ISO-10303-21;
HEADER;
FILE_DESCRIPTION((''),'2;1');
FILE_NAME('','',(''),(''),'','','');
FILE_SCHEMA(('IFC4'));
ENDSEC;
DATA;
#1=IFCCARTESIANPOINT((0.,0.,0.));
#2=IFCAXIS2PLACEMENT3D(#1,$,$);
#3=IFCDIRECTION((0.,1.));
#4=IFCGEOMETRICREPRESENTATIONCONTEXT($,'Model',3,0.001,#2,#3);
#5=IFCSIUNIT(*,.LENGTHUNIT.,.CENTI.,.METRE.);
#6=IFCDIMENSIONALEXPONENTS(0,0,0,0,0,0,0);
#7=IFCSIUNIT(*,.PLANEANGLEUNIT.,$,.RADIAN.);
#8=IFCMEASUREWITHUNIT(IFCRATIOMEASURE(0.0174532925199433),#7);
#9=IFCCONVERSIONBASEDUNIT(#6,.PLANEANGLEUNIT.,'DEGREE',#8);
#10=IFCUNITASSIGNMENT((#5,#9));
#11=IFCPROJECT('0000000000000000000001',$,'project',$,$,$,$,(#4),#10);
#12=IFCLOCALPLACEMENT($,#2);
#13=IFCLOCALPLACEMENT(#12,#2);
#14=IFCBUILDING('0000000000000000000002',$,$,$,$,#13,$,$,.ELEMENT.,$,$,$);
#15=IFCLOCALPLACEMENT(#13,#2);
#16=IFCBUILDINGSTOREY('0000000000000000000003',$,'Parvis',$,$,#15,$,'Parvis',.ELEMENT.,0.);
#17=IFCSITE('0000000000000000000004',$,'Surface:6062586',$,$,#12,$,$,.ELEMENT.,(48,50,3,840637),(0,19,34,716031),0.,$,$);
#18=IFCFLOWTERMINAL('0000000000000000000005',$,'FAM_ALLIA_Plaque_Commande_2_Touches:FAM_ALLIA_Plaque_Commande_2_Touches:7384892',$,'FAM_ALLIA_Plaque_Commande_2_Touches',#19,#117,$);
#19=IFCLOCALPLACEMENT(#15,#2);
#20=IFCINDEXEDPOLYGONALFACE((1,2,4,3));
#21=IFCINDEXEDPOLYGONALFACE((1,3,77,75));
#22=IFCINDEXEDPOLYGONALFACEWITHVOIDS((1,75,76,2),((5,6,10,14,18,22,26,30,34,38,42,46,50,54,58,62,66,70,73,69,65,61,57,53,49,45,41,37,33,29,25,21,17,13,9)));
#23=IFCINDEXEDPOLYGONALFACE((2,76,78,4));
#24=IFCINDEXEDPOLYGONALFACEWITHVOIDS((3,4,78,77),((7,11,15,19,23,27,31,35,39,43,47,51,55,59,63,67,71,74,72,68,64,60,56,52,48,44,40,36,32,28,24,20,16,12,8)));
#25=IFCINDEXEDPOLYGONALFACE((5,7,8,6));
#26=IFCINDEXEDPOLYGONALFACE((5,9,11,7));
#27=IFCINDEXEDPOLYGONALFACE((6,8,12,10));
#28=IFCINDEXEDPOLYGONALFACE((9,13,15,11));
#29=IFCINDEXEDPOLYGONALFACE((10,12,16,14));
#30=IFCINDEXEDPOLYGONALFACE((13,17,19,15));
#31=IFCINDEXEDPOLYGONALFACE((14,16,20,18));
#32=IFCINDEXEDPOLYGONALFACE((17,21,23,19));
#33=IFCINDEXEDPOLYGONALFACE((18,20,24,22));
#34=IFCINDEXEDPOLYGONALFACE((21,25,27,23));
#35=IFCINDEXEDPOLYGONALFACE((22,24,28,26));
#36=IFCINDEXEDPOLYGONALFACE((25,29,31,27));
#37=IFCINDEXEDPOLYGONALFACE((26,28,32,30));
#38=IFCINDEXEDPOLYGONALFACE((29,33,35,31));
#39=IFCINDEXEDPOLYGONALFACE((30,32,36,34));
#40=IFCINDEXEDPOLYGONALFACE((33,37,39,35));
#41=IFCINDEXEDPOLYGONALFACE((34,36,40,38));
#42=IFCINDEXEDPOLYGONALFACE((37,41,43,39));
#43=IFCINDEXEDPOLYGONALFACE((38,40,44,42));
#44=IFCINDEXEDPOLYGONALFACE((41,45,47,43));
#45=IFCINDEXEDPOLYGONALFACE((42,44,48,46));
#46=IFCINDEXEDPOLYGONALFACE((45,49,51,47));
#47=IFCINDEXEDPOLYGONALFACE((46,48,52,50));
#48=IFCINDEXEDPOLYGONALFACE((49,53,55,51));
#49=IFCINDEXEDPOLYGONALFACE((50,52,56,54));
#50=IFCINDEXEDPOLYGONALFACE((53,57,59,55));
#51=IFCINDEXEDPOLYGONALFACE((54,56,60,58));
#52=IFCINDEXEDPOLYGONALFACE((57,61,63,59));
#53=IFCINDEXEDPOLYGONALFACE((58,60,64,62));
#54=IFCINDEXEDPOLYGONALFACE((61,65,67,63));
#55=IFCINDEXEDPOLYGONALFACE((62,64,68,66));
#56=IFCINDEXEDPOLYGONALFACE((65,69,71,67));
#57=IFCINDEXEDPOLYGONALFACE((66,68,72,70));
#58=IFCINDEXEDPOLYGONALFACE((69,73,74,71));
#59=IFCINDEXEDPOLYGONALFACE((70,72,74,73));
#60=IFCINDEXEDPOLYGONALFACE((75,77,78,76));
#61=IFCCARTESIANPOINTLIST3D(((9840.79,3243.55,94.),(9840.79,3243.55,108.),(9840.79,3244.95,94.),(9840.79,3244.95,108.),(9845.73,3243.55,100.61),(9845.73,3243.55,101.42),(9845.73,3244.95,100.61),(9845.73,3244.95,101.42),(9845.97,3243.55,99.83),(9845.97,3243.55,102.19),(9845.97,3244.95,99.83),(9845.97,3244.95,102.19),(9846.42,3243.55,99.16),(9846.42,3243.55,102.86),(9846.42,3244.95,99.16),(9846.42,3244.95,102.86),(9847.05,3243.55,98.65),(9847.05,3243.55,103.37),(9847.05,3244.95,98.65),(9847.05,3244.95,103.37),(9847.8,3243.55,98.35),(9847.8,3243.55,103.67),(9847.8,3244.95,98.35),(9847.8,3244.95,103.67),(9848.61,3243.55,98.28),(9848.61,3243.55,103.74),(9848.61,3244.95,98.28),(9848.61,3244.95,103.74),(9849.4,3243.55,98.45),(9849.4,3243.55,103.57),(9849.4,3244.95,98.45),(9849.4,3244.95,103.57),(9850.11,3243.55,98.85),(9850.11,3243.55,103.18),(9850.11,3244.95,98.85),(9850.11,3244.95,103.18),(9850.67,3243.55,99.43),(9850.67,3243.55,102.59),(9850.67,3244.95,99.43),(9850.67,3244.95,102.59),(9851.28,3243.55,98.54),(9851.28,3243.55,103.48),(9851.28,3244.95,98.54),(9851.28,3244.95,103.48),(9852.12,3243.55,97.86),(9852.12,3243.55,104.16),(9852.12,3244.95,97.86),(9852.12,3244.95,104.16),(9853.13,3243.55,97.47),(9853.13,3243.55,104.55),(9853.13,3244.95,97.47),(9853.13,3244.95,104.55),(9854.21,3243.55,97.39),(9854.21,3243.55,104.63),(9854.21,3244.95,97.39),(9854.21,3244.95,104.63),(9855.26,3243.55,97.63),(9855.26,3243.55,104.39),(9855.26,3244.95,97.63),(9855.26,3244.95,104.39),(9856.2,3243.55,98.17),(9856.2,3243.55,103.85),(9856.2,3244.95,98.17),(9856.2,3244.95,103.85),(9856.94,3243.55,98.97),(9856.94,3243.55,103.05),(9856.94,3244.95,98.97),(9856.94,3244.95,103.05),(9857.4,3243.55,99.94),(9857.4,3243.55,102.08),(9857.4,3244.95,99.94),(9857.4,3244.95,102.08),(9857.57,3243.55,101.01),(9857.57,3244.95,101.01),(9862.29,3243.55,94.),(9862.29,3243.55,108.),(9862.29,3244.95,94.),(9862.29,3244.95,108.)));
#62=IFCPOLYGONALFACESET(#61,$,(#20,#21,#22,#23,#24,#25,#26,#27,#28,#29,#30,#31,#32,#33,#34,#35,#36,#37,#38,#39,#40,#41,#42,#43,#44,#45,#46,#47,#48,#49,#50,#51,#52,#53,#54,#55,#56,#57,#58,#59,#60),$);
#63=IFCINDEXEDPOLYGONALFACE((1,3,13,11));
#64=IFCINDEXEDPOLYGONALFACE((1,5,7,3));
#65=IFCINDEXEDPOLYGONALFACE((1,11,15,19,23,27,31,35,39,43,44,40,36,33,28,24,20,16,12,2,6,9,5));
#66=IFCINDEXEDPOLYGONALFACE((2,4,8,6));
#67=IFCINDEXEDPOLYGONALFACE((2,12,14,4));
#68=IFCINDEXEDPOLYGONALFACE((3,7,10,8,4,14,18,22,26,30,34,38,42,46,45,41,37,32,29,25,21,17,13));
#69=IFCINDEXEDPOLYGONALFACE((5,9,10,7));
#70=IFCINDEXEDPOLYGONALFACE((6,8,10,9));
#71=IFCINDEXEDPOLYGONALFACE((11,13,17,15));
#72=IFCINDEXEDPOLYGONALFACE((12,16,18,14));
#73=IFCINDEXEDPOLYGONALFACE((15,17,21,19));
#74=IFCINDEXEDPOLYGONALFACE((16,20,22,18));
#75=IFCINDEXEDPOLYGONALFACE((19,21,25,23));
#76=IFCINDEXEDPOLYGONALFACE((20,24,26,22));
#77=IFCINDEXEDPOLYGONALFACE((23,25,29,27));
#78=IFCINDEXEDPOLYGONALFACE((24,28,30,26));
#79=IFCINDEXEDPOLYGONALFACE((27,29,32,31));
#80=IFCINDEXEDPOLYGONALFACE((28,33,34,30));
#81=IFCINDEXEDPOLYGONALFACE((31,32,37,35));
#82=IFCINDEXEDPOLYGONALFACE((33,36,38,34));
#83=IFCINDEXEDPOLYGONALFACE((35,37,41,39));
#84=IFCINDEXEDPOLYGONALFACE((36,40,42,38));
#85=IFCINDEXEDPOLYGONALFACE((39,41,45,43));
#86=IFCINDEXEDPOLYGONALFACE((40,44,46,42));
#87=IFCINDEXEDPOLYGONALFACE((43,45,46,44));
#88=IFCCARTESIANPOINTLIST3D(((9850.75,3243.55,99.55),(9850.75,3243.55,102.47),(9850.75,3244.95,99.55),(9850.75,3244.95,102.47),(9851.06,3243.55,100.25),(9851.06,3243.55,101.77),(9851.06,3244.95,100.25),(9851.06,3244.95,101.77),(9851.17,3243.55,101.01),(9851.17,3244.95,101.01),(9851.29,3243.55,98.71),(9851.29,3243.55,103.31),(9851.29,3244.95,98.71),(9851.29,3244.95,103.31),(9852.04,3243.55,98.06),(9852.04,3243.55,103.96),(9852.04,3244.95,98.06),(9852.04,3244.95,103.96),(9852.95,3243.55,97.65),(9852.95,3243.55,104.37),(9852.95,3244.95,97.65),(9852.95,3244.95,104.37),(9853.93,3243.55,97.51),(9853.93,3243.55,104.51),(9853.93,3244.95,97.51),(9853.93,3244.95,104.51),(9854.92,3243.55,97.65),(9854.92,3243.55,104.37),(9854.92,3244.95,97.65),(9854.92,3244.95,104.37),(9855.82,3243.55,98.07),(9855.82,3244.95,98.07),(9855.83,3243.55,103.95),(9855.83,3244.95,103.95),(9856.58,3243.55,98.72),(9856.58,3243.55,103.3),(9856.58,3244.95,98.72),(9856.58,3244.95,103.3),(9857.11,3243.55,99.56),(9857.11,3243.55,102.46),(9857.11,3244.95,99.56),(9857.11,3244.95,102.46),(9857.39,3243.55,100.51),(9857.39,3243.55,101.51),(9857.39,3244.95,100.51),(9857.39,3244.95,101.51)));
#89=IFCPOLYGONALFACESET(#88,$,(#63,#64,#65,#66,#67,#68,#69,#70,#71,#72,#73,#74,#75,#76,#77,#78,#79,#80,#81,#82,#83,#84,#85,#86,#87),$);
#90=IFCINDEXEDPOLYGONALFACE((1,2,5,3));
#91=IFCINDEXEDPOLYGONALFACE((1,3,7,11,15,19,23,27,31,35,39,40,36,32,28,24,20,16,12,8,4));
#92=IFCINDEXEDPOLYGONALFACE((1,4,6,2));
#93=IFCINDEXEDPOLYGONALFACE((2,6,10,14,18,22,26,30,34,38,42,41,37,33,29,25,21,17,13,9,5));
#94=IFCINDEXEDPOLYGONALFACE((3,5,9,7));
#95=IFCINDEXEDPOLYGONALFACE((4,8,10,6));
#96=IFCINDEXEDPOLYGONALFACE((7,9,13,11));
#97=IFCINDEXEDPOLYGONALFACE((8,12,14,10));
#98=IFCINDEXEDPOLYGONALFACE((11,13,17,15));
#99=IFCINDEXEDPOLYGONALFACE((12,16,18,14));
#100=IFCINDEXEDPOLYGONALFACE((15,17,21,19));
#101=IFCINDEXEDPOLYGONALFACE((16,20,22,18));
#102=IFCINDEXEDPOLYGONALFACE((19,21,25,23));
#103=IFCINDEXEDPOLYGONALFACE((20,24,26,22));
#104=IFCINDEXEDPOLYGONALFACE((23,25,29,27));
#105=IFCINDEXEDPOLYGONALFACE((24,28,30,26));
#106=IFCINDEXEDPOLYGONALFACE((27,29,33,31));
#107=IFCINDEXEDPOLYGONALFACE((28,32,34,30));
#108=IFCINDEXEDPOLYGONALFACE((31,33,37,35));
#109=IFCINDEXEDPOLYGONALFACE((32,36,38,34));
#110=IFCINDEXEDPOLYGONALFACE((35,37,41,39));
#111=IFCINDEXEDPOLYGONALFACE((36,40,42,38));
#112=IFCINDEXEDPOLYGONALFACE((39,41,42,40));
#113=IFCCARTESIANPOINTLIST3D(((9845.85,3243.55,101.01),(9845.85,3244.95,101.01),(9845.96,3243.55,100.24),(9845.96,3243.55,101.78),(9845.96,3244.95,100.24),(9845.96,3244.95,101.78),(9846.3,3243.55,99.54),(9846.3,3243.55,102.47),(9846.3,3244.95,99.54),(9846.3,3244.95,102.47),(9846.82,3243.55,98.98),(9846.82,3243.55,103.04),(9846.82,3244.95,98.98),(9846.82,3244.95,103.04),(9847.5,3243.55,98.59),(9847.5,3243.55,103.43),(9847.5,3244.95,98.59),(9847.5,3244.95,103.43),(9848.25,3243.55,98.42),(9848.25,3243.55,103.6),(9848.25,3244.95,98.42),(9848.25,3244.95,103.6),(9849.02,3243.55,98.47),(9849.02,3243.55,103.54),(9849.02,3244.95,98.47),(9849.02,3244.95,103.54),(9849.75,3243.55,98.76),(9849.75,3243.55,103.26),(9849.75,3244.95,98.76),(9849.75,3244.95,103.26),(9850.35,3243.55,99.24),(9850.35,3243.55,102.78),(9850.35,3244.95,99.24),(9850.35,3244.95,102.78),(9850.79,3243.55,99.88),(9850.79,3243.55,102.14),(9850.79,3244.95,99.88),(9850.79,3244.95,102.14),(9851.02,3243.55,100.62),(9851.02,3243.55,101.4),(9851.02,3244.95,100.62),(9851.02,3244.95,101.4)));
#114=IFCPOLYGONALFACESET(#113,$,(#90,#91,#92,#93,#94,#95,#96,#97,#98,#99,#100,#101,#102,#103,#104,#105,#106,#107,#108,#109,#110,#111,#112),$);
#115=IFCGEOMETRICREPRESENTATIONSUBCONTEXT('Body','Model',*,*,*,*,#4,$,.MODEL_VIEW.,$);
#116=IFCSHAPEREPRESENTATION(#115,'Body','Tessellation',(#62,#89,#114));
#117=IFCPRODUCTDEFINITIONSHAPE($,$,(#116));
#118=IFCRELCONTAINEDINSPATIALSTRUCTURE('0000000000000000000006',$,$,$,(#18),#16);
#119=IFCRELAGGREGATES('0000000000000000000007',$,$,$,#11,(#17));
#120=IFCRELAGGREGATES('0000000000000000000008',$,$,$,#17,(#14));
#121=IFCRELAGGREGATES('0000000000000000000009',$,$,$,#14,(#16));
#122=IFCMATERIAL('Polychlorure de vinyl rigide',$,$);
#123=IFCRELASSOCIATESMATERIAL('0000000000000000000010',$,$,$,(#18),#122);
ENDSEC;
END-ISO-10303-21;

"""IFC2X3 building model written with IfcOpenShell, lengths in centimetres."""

from ifc_helpers import new_model, entity, si_unit, converted_unit, direction, frame, frame_2d, origin, place, context, subcontext, project, spatial, polyline, circle_curve, parameter, trimmed, segment, composite_curve, circle, outline, extrude, source, transform, mapped, material, element, save


model = new_model("IFC2X3")

# Units and contexts
model_context = context("Model", 3, precision=0.001, world=origin(), true_north=direction((0.0, 1.0)))
body_context = subcontext(model_context, "Body", "Model", "MODEL_VIEW")
ifc_project = project(units=[si_unit("LENGTHUNIT", "METRE", prefix="CENTI"), converted_unit("PLANEANGLEUNIT", "DEGREE", entity("IfcRatioMeasure", 0.0174532925199433), si_unit("PLANEANGLEUNIT", "RADIAN"), dimensions=[0, 0, 0, 0, 0, 0, 0])], contexts=[model_context])

# Site, building, storey
site_placement = place(None, origin())
site = spatial("IfcSite", under=ifc_project, at=site_placement, Name="Surface:6062586", CompositionType="ELEMENT", RefLatitude=(48, 50, 3, 840637), RefLongitude=(0, 19, 34, 716031), RefElevation=0.0)
building_placement = place(site_placement, origin())
building = spatial("IfcBuilding", under=site, at=building_placement, CompositionType="ELEMENT")
storey_placement = place(building_placement, frame((0.0, 0.0, 0.0)))
storey = spatial("IfcBuildingStorey", under=building, at=storey_placement, Name="Parvis", LongName="Parvis", CompositionType="ELEMENT", Elevation=0.0)

# Flow terminal
ifc_material_1 = material(Name="Polychlorure de vinyl rigide")
shared_shape_1 = source(origin(), body_context, "Body", "SweptSolid", [
    extrude(outline(polyline([(-10.75, -7.0), (10.75, -7.0), (10.75, 7.0), (-10.75, 7.0), (-10.75, -7.0)]), holes=[composite_curve([segment(trimmed(circle_curve(frame_2d((2.39, 0.01), x_axis=(-1.0, 0.0)), 3.63), [parameter(25.817037)], [parameter(334.182963)], True, "PARAMETER"), False, "CONTINUOUS"), segment(trimmed(circle_curve(frame_2d((-3.1, 0.01), x_axis=(-1.0, 0.0)), 2.73), [parameter(215.328783)], [parameter(144.671217)], True, "PARAMETER"), False, "CONTINUOUS")], self_intersect=False)]), frame((10.75, 0.0, 7.0), z_axis=(0.0, 1.0, 0.0), x_axis=(-1.0, 0.0, 0.0)), (0.0, 0.0, 1.0), 1.4),
    extrude(outline(composite_curve([segment(trimmed(circle_curve(frame_2d((-3.18, 0.0), x_axis=(1.0, 0.0)), 3.5), [parameter(24.658608)], [parameter(335.369251)], True, "PARAMETER"), True, "CONTINUOUS"), segment(trimmed(circle_curve(frame_2d((2.31, 0.0), x_axis=(1.0, 0.0)), 2.73), [parameter(147.747195)], [parameter(212.280664)], True, "PARAMETER"), False, "CONTINUOUS")], self_intersect=False)), frame((11.54, 0.0, 7.01), z_axis=(0.0, -1.0, 0.0), x_axis=(1.0, 0.0, 0.0)), (0.0, 0.0, -1.0), 1.4),
    extrude(circle(Radius=2.6, at=frame_2d((0.0, 0.0), x_axis=(1.0, 0.0))), frame((13.85, 0.0, 7.01), z_axis=(0.0, 1.0, 0.0), x_axis=(1.0, 0.0, 0.0)), (0.0, 0.0, 1.0), 1.4),
])
for number, where, z_axis, x_axis, name in (
    (1, (9862.29, 3244.95, 94.0), (0.0, 0.0, 1.0), (-1.0, 0.0, 0.0), "FAM_ALLIA_Plaque_Commande_2_Touches:FAM_ALLIA_Plaque_Commande_2_Touches:7384892"),
):
    element("IfcFlowTerminal", number, at=place(storey_placement, frame(where, z_axis=z_axis, x_axis=x_axis)), inside=storey, material=ifc_material_1, Name=name, ObjectType="FAM_ALLIA_Plaque_Commande_2_Touches", context=body_context, shape_type="MappedRepresentation", body=[
        mapped(shared_shape_1, transform((0.0, 0.0, 0.0), scale=1.0)),
    ])

save(model, "model.ifc")
